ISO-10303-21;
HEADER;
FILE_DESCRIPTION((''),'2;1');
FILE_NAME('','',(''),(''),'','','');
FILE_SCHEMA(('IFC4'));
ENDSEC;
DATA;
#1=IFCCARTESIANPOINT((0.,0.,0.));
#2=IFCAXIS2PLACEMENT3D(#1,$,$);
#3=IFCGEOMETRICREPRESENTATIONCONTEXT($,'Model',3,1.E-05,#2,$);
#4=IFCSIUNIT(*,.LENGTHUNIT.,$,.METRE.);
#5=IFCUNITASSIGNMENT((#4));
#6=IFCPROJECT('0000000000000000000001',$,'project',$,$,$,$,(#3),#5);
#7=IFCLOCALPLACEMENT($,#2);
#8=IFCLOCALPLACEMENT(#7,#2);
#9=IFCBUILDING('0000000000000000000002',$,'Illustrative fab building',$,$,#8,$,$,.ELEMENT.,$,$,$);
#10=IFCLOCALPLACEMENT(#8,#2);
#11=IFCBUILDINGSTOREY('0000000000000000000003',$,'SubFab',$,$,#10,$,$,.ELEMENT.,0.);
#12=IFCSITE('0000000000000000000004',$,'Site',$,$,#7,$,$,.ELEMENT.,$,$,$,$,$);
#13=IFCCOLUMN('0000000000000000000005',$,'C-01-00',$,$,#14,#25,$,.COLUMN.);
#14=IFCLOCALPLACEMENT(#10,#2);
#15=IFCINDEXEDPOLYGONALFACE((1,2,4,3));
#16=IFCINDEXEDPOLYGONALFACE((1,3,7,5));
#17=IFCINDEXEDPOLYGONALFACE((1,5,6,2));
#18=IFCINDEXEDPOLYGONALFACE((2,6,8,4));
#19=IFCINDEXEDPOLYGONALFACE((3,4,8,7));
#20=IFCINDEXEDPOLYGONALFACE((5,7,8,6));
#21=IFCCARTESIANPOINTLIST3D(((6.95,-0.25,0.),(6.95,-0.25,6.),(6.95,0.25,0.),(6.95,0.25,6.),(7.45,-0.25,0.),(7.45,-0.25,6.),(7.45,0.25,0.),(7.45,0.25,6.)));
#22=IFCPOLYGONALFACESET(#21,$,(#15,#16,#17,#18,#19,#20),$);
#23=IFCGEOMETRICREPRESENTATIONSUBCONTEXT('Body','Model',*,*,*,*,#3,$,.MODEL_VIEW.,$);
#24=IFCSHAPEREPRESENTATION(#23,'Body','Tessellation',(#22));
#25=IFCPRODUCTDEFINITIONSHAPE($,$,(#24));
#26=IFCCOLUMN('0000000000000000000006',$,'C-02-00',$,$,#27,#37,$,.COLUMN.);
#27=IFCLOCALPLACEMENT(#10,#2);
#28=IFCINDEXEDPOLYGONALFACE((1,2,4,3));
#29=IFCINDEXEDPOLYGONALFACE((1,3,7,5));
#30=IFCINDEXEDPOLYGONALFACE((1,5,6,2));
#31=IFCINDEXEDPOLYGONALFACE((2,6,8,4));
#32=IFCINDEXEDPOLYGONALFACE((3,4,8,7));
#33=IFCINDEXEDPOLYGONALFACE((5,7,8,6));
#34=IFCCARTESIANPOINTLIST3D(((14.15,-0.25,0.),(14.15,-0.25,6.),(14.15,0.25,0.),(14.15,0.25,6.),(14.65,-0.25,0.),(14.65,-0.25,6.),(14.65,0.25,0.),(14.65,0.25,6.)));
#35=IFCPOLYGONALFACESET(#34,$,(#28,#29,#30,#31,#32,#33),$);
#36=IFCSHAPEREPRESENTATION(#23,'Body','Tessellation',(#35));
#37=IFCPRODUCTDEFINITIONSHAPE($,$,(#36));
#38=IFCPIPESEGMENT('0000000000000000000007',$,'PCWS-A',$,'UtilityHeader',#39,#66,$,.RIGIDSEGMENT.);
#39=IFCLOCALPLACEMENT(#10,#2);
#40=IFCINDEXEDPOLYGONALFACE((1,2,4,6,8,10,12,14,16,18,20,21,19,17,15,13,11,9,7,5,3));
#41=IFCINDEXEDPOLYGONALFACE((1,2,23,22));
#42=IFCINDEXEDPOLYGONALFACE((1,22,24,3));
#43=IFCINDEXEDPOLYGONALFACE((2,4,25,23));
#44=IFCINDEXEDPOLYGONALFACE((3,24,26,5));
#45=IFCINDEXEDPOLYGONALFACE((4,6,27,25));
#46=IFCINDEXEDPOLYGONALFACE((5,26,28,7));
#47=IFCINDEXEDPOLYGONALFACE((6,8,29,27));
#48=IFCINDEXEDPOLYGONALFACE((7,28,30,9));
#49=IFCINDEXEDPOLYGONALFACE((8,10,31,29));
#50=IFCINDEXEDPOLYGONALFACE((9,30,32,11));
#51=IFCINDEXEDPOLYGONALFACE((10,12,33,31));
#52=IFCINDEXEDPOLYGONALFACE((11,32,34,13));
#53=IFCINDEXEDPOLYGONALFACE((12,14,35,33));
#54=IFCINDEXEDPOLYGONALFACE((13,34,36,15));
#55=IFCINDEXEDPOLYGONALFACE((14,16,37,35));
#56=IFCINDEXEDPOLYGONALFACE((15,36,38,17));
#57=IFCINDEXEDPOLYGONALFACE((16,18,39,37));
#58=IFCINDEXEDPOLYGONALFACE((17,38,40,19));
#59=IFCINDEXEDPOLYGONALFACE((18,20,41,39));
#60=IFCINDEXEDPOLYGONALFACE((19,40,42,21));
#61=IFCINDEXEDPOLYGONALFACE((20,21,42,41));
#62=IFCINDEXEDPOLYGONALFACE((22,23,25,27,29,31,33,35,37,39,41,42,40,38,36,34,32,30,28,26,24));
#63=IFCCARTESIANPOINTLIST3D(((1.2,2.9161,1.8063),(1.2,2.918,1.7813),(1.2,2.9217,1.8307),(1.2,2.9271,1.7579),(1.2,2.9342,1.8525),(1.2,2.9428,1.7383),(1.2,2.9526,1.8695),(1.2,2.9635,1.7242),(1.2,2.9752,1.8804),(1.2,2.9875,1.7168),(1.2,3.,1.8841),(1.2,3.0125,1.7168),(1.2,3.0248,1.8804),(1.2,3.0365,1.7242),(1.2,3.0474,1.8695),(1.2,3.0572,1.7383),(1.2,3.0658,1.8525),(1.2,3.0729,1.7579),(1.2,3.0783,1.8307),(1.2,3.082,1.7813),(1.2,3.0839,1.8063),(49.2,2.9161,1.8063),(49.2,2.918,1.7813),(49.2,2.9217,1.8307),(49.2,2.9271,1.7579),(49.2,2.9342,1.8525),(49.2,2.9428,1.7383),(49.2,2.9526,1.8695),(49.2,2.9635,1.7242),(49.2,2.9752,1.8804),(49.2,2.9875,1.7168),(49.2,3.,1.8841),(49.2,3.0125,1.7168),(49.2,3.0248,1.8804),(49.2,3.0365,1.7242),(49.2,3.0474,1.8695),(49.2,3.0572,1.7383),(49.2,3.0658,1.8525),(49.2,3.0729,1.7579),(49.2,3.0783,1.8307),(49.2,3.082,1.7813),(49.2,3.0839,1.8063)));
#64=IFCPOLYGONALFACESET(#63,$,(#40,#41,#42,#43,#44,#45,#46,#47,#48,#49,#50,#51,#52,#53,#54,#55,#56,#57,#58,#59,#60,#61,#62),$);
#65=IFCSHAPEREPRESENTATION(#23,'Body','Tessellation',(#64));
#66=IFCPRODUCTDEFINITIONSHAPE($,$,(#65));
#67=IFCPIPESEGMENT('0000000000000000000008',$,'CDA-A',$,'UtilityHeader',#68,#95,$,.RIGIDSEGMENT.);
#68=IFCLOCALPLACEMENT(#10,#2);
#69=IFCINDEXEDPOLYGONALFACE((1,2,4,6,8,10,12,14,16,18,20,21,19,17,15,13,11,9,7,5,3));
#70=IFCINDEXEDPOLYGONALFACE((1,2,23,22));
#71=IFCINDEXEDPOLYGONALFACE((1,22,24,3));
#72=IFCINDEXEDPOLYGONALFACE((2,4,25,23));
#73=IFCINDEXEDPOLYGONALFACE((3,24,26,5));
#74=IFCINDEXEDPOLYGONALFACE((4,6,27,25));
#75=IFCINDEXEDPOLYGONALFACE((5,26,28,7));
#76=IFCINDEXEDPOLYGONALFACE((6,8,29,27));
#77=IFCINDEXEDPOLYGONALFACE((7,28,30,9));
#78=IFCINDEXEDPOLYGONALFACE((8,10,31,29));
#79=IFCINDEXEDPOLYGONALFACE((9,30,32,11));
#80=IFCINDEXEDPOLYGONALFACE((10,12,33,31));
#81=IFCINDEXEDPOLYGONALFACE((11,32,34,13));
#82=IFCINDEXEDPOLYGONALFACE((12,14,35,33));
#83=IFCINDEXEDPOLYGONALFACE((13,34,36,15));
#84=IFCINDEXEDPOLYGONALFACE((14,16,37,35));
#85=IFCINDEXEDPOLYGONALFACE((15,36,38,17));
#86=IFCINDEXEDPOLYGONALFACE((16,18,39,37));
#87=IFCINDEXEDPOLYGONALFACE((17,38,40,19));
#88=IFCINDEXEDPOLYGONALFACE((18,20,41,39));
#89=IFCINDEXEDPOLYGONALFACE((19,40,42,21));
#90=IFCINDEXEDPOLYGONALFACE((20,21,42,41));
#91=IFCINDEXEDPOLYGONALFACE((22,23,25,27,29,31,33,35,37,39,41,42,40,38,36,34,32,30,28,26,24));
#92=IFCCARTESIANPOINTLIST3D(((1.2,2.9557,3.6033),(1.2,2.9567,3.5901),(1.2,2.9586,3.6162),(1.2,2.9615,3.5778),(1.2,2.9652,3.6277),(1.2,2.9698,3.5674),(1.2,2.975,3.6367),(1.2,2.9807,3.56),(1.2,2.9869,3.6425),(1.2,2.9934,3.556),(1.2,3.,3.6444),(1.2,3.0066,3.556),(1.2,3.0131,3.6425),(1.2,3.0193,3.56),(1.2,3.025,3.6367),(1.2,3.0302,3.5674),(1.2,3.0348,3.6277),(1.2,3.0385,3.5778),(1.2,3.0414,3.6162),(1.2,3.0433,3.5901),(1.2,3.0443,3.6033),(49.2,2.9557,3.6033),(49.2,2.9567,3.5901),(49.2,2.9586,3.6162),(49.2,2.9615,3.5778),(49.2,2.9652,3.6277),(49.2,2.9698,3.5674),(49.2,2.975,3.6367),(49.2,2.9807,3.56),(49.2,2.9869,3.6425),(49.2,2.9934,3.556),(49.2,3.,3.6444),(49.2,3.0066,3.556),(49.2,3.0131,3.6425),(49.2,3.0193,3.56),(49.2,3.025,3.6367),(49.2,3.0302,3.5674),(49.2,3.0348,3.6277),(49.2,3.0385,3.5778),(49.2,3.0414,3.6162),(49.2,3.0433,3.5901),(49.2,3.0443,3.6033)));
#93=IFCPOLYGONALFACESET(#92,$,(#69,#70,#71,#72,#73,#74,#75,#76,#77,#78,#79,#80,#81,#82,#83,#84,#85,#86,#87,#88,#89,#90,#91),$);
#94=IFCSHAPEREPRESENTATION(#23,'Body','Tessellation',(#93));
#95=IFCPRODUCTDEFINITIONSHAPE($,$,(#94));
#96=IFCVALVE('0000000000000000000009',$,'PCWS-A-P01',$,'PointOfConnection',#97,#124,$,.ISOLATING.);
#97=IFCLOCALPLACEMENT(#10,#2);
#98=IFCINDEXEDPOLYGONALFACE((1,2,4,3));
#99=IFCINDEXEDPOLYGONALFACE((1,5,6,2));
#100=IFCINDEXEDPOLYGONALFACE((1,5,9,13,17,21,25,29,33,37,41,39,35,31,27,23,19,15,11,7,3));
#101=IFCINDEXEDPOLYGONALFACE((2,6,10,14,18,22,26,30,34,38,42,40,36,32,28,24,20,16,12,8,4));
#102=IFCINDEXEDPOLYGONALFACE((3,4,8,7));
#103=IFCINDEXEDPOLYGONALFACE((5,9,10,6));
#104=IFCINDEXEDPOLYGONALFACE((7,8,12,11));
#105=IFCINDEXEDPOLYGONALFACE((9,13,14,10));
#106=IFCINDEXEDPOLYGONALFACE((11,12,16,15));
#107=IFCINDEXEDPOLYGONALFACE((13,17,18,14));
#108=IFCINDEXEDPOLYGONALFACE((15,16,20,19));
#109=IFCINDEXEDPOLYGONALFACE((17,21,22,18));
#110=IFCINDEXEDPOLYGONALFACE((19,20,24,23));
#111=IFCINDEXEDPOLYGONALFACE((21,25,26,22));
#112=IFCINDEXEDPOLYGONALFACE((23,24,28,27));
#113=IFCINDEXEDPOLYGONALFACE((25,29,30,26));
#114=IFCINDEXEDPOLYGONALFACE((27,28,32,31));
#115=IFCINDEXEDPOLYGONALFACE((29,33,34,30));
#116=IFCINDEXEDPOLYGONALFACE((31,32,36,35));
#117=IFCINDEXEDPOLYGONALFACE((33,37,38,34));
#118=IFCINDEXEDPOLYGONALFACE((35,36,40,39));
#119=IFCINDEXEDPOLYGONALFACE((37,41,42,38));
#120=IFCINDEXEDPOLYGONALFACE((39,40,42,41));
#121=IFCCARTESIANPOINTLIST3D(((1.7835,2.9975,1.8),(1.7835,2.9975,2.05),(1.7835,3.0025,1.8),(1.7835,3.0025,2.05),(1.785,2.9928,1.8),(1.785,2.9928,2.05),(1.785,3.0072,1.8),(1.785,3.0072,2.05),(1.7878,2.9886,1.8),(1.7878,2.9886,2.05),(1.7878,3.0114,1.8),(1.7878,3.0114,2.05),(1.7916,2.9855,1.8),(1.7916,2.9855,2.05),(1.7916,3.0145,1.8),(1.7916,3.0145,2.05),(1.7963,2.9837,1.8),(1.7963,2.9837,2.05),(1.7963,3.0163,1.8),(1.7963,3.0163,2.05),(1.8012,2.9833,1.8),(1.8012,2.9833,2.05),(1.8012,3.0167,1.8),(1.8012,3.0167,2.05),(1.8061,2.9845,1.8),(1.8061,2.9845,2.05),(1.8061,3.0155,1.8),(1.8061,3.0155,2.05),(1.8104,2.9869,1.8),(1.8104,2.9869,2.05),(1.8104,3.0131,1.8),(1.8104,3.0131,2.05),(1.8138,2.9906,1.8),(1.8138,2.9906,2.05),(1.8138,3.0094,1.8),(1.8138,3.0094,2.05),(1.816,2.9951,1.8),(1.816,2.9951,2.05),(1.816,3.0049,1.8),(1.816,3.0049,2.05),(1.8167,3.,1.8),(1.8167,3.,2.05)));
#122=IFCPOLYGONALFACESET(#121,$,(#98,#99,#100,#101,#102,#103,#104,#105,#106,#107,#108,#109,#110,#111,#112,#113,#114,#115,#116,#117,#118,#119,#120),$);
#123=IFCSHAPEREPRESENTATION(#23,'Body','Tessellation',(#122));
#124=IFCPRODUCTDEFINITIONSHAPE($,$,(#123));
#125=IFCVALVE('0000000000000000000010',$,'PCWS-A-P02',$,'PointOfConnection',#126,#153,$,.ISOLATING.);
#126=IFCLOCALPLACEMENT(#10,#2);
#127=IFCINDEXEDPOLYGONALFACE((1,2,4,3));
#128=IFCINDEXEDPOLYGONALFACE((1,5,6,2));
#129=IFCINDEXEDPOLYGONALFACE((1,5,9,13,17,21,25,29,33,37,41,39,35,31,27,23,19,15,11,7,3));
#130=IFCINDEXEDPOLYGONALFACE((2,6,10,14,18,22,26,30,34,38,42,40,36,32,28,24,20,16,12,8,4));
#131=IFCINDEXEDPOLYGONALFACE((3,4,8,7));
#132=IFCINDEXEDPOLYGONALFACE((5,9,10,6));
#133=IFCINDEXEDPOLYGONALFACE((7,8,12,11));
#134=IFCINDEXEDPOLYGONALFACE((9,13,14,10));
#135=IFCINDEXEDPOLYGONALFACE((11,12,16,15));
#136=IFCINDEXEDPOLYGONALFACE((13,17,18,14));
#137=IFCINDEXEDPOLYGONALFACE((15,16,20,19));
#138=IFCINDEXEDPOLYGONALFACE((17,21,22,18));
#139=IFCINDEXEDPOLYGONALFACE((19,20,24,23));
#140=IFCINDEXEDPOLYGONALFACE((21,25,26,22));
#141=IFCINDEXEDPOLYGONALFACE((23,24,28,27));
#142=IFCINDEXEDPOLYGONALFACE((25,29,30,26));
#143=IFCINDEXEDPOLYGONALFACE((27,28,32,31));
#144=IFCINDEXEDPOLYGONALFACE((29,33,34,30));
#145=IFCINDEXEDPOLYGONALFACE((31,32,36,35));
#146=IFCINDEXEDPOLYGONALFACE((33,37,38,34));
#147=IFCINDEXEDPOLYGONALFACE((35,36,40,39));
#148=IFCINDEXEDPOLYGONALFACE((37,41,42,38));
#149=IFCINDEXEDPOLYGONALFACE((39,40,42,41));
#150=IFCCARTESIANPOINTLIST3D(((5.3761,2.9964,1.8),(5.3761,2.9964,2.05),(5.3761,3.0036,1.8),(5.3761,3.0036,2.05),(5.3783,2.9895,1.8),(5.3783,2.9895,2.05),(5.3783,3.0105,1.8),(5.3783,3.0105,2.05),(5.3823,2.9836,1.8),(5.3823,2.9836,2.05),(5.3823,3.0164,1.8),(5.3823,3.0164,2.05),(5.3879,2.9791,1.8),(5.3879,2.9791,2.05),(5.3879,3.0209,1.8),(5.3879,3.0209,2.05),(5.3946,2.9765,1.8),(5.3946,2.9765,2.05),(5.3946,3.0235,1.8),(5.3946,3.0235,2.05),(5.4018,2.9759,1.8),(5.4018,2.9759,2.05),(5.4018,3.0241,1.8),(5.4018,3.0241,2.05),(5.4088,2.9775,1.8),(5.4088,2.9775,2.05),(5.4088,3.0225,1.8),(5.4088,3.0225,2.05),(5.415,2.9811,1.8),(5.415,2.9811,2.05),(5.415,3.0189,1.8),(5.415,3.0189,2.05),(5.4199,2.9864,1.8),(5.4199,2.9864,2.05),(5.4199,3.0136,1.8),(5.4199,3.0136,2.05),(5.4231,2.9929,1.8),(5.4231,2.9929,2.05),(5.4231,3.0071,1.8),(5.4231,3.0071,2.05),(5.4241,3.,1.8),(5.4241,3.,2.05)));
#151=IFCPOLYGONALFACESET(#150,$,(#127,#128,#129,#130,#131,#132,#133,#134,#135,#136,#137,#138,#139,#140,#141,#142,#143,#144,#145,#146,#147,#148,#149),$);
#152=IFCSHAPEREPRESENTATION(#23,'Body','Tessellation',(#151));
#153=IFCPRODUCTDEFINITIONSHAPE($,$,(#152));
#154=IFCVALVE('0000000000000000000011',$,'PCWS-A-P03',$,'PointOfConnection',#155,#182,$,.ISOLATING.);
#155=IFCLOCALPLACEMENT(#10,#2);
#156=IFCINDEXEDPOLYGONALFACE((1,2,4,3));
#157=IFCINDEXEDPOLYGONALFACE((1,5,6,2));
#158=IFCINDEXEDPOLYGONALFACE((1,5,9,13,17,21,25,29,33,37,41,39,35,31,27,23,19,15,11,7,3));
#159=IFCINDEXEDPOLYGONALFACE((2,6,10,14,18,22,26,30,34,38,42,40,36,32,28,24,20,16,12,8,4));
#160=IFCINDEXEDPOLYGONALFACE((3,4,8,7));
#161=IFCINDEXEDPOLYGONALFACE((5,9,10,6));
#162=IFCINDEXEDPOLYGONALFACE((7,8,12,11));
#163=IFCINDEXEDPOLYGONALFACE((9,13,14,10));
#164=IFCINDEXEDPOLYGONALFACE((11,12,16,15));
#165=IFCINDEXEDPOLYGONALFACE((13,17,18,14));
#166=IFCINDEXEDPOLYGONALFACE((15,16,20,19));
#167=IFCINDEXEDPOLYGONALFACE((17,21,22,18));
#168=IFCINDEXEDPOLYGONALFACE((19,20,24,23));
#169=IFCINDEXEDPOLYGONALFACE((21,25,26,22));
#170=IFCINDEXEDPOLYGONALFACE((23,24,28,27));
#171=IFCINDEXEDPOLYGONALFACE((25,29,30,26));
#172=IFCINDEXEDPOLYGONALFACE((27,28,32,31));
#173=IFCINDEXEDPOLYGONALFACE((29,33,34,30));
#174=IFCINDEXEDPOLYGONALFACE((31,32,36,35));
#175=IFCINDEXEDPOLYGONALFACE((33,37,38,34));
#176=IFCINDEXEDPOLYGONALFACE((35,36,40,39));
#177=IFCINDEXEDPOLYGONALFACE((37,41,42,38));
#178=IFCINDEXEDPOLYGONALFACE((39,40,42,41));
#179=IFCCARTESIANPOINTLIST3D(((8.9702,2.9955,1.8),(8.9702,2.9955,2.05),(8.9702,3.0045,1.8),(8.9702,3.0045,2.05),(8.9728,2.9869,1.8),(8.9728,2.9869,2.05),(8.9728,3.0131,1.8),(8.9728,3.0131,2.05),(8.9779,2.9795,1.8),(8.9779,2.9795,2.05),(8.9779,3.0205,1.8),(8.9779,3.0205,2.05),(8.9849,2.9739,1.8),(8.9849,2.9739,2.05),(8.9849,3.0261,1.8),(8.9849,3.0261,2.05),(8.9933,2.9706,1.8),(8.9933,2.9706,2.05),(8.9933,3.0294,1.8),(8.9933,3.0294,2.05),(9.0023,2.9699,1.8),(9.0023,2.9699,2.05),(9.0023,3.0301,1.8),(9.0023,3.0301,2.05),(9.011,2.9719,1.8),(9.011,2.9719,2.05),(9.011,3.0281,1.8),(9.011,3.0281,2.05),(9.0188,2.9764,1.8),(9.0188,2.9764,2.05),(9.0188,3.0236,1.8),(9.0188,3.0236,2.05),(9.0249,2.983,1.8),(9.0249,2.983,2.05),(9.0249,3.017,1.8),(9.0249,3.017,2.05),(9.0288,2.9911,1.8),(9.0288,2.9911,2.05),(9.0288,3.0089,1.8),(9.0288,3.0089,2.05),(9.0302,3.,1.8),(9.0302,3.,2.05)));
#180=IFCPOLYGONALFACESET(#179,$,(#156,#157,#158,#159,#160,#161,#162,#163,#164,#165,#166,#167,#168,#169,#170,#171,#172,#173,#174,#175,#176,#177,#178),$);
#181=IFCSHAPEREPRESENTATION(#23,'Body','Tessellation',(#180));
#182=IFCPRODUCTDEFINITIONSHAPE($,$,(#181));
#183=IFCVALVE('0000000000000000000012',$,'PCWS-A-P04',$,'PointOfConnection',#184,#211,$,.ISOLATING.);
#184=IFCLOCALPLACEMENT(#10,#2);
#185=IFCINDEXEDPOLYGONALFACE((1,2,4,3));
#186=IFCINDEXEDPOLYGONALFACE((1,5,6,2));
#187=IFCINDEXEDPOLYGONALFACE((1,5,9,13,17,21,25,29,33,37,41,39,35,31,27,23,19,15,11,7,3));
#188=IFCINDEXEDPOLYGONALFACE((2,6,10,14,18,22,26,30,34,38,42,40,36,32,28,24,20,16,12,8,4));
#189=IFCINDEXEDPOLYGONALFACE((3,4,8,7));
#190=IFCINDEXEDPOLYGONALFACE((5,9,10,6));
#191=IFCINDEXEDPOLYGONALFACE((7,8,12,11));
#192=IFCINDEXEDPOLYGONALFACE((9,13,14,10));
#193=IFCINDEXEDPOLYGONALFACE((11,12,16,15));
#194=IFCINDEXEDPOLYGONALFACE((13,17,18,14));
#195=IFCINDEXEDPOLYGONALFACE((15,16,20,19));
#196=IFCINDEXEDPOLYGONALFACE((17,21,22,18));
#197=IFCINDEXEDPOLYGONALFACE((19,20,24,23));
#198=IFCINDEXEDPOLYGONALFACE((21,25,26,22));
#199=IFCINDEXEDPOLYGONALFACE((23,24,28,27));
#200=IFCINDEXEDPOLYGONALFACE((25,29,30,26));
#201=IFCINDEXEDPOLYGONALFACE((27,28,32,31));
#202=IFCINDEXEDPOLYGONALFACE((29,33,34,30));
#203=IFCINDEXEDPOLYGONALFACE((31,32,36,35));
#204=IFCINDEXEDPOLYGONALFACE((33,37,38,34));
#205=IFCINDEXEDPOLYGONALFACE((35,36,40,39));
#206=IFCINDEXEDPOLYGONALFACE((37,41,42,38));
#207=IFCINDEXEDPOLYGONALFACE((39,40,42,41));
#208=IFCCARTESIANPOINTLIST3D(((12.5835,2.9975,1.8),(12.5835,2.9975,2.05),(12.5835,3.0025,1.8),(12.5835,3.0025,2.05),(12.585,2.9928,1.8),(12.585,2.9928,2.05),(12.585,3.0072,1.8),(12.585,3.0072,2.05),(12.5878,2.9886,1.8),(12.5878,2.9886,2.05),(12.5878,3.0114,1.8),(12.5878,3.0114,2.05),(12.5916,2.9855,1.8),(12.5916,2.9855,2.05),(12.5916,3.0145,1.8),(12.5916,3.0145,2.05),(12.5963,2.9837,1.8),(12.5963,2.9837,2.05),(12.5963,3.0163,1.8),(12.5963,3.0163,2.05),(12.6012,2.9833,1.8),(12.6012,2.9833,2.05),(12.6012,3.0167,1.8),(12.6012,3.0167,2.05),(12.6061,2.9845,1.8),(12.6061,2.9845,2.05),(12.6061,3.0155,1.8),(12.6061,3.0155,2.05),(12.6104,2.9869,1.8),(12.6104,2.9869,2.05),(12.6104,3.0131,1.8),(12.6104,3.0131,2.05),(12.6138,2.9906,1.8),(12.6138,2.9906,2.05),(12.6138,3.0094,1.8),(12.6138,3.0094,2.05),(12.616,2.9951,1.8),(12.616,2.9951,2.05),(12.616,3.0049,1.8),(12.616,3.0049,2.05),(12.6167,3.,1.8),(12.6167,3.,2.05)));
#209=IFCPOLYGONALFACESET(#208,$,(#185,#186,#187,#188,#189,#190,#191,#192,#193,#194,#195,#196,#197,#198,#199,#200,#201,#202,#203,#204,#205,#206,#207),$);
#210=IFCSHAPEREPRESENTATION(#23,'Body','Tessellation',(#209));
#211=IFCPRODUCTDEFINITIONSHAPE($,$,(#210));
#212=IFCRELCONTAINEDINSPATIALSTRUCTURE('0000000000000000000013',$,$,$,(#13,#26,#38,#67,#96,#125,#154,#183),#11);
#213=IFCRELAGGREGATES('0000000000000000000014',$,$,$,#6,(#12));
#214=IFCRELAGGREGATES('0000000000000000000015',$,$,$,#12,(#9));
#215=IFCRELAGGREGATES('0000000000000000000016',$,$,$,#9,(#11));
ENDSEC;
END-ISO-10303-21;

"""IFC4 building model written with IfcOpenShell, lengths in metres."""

from ifc_helpers import new_model, entity, si_unit, frame, origin, origin_2d, place, context, subcontext, project, spatial, rectangle, extrude, element, save


model = new_model("IFC4")

# Units and contexts
model_context = context("Model", 3, precision=1e-05, world=origin())
body_context = subcontext(model_context, "Body", "Model", "MODEL_VIEW")
ifc_project = project(units=[si_unit("LENGTHUNIT", "METRE")], contexts=[model_context])

# Site, building, storey
site_placement = place(None, origin())
site = spatial("IfcSite", under=ifc_project, at=site_placement, Name="Site", CompositionType="ELEMENT")
building_placement = place(site_placement, origin())
building = spatial("IfcBuilding", under=site, at=building_placement, Name="Illustrative fab building", CompositionType="ELEMENT")
storey_placement = place(building_placement, origin())
storey = spatial("IfcBuildingStorey", under=building, at=storey_placement, Name="SubFab", CompositionType="ELEMENT", Elevation=0.0)

# Columns
for number, where, name in (
    (1, (7.2, 0.0, 0.0), "C-01-00"),
    (2, (14.4, 0.0, 0.0), "C-02-00"),
):
    element("IfcColumn", number, at=place(storey_placement, frame(where)), inside=storey, Name=name, PredefinedType="COLUMN", context=body_context, shape_type="SweptSolid", body=[
        extrude(rectangle(XDim=0.5, YDim=0.5, at=origin_2d()), origin(), (0.0, 0.0, 1.0), 6.0),
    ])

# Pipe segments
pipe_segment_1_placement = place(storey_placement, frame((1.2, 3.0, 1.8)))
element("IfcPipeSegment", 3, at=pipe_segment_1_placement, inside=storey, Name="PCWS-A", ObjectType="UtilityHeader", PredefinedType="RIGIDSEGMENT", context=body_context, shape_type="AdvancedSweptSolid", body=[
    entity("IfcSweptDiskSolid", entity("IfcPolyline", [entity("IfcCartesianPoint", [0.0, 0.0, 0.0]), entity("IfcCartesianPoint", [48.0, 0.0, 0.0])]), 0.0841),
])
pipe_segment_2_placement = place(storey_placement, frame((1.2, 3.0, 3.6)))
element("IfcPipeSegment", 4, at=pipe_segment_2_placement, inside=storey, Name="CDA-A", ObjectType="UtilityHeader", PredefinedType="RIGIDSEGMENT", context=body_context, shape_type="AdvancedSweptSolid", body=[
    entity("IfcSweptDiskSolid", entity("IfcPolyline", [entity("IfcCartesianPoint", [0.0, 0.0, 0.0]), entity("IfcCartesianPoint", [48.0, 0.0, 0.0])]), 0.0445),
])

# Valves
valve_1_placement = place(storey_placement, frame((1.8, 3.0, 1.8)))
element("IfcValve", 5, at=valve_1_placement, inside=storey, Name="PCWS-A-P01", ObjectType="PointOfConnection", PredefinedType="ISOLATING", context=body_context, shape_type="AdvancedSweptSolid", body=[
    entity("IfcSweptDiskSolid", entity("IfcPolyline", [entity("IfcCartesianPoint", [0.0, 0.0, 0.0]), entity("IfcCartesianPoint", [0.0, 0.0, 0.25])]), 0.0167),
])
valve_2_placement = place(storey_placement, frame((5.4, 3.0, 1.8)))
element("IfcValve", 6, at=valve_2_placement, inside=storey, Name="PCWS-A-P02", ObjectType="PointOfConnection", PredefinedType="ISOLATING", context=body_context, shape_type="AdvancedSweptSolid", body=[
    entity("IfcSweptDiskSolid", entity("IfcPolyline", [entity("IfcCartesianPoint", [0.0, 0.0, 0.0]), entity("IfcCartesianPoint", [0.0, 0.0, 0.25])]), 0.0241),
])
valve_3_placement = place(storey_placement, frame((9.0, 3.0, 1.8)))
element("IfcValve", 7, at=valve_3_placement, inside=storey, Name="PCWS-A-P03", ObjectType="PointOfConnection", PredefinedType="ISOLATING", context=body_context, shape_type="AdvancedSweptSolid", body=[
    entity("IfcSweptDiskSolid", entity("IfcPolyline", [entity("IfcCartesianPoint", [0.0, 0.0, 0.0]), entity("IfcCartesianPoint", [0.0, 0.0, 0.25])]), 0.0302),
])
valve_4_placement = place(storey_placement, frame((12.6, 3.0, 1.8)))
element("IfcValve", 8, at=valve_4_placement, inside=storey, Name="PCWS-A-P04", ObjectType="PointOfConnection", PredefinedType="ISOLATING", context=body_context, shape_type="AdvancedSweptSolid", body=[
    entity("IfcSweptDiskSolid", entity("IfcPolyline", [entity("IfcCartesianPoint", [0.0, 0.0, 0.0]), entity("IfcCartesianPoint", [0.0, 0.0, 0.25])]), 0.0167),
])

save(model, "model.ifc")
